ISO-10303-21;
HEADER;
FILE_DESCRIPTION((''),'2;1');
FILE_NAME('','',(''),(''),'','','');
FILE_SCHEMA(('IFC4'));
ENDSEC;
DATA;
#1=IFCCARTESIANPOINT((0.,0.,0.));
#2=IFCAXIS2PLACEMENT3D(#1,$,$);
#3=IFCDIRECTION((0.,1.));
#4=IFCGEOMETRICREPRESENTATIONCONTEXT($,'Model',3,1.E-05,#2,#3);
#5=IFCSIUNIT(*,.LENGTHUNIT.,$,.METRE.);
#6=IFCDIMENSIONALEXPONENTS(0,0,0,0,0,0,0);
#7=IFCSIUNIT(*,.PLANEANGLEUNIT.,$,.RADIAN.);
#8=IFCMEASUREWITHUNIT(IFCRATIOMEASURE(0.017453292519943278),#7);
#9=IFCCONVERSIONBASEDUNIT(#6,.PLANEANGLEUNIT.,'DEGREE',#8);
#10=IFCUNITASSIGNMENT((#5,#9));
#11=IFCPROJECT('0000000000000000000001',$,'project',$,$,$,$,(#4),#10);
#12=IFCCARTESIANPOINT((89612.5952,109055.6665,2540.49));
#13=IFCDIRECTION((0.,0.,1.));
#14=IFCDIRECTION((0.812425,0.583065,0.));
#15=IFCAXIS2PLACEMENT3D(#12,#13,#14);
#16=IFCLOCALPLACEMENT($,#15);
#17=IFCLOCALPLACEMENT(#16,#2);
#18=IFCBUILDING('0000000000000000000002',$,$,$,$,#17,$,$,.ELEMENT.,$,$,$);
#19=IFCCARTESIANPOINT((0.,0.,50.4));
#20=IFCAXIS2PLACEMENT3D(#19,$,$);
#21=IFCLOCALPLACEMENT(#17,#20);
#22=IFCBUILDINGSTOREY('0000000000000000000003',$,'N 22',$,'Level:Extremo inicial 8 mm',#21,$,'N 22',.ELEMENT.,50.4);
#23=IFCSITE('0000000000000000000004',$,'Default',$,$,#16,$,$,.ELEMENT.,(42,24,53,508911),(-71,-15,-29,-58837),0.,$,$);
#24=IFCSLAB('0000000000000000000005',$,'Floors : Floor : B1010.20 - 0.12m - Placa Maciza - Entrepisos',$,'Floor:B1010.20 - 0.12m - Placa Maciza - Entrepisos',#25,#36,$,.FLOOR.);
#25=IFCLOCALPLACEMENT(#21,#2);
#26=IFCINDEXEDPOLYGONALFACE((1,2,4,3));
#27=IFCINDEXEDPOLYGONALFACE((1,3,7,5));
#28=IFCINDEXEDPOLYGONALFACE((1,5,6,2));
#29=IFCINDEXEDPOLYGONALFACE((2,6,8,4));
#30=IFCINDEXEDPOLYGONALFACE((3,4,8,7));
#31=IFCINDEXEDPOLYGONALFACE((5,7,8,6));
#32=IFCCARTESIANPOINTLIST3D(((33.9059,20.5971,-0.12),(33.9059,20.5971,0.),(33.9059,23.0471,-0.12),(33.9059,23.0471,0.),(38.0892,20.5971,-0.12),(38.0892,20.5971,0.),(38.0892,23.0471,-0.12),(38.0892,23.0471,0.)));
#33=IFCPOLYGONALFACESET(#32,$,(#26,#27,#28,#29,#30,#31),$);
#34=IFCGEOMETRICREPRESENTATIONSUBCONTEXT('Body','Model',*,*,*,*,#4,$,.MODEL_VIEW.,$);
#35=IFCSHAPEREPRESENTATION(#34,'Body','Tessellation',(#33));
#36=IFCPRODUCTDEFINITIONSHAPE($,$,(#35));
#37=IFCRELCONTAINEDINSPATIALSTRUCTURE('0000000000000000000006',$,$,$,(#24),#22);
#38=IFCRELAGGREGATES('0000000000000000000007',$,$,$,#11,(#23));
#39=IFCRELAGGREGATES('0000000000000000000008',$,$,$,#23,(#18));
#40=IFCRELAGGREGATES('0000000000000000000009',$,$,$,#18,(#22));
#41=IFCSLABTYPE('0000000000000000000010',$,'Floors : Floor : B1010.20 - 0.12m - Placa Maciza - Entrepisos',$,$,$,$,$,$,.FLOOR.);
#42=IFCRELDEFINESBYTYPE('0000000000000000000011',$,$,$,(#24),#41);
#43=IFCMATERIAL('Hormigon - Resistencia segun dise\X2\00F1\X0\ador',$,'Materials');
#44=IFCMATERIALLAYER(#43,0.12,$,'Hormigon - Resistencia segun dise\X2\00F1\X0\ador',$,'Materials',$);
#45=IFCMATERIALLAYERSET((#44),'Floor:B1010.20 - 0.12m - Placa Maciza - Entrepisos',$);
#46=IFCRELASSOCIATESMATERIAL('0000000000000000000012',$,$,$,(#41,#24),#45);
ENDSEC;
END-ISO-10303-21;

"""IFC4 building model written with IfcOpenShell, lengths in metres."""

from ifc_helpers import new_model, entity, si_unit, converted_unit, direction, frame, frame_2d, origin, place, context, subcontext, project, spatial, rectangle, extrude, material, layer, layer_set, layer_usage, type_object, element, save


model = new_model("IFC4")

# Units and contexts
model_context = context("Model", 3, precision=1e-05, world=origin(), true_north=direction((0.0, 1.0)))
body_context = subcontext(model_context, "Body", "Model", "MODEL_VIEW")
ifc_project = project(units=[si_unit("LENGTHUNIT", "METRE"), converted_unit("PLANEANGLEUNIT", "DEGREE", entity("IfcRatioMeasure", 0.017453292519943278), si_unit("PLANEANGLEUNIT", "RADIAN"), dimensions=[0, 0, 0, 0, 0, 0, 0])], contexts=[model_context])

# Site, building, storey
site_placement = place(None, frame((89612.5952, 109055.6665, 2540.49), z_axis=(0.0, 0.0, 1.0), x_axis=(0.812425, 0.583065, 0.0)))
site = spatial("IfcSite", under=ifc_project, at=site_placement, Name="Default", CompositionType="ELEMENT", RefLatitude=(42, 24, 53, 508911), RefLongitude=(-71, -15, -29, -58837), RefElevation=0.0)
building_placement = place(site_placement, origin())
building = spatial("IfcBuilding", under=site, at=building_placement, CompositionType="ELEMENT")
storey_placement = place(building_placement, frame((0.0, 0.0, 50.4)))
storey = spatial("IfcBuildingStorey", under=building, at=storey_placement, Name="N 22", ObjectType="Level:Extremo inicial 8 mm", LongName="N 22", CompositionType="ELEMENT", Elevation=50.4)

# Slab
ifc_material = material(Name="Hormigon - Resistencia segun diseñador", Category="Materials")
ifc_layer = layer(ifc_material, 0.12, Name="Hormigon - Resistencia segun diseñador", Category="Materials")
ifc_layer_set = layer_set([ifc_layer], Name="Floor:B1010.20 - 0.12m - Placa Maciza - Entrepisos")
ifc_layer_usage = layer_usage(ifc_layer_set, "AXIS3", "POSITIVE", 0.0)
slab_type = type_object("IfcSlabType", Name="Floors : Floor : B1010.20 - 0.12m - Placa Maciza - Entrepisos", PredefinedType="FLOOR", material=ifc_layer_set)
slab_placement = place(storey_placement, origin())
element("IfcSlab", 1, at=slab_placement, inside=storey, type_object=slab_type, material=ifc_layer_usage, Name="Floors : Floor : B1010.20 - 0.12m - Placa Maciza - Entrepisos", ObjectType="Floor:B1010.20 - 0.12m - Placa Maciza - Entrepisos", PredefinedType="FLOOR", context=body_context, shape_type="SweptSolid", body=[
    extrude(rectangle(XDim=2.45, YDim=4.1833, at=frame_2d((0.0, 0.0), x_axis=(1.0, 0.0))), frame((35.9976, 21.8221, 0.0), z_axis=(0.0, 0.0, -1.0), x_axis=(0.0, 1.0, 0.0)), (0.0, 0.0, 1.0), 0.12),
])

save(model, "model.ifc")
